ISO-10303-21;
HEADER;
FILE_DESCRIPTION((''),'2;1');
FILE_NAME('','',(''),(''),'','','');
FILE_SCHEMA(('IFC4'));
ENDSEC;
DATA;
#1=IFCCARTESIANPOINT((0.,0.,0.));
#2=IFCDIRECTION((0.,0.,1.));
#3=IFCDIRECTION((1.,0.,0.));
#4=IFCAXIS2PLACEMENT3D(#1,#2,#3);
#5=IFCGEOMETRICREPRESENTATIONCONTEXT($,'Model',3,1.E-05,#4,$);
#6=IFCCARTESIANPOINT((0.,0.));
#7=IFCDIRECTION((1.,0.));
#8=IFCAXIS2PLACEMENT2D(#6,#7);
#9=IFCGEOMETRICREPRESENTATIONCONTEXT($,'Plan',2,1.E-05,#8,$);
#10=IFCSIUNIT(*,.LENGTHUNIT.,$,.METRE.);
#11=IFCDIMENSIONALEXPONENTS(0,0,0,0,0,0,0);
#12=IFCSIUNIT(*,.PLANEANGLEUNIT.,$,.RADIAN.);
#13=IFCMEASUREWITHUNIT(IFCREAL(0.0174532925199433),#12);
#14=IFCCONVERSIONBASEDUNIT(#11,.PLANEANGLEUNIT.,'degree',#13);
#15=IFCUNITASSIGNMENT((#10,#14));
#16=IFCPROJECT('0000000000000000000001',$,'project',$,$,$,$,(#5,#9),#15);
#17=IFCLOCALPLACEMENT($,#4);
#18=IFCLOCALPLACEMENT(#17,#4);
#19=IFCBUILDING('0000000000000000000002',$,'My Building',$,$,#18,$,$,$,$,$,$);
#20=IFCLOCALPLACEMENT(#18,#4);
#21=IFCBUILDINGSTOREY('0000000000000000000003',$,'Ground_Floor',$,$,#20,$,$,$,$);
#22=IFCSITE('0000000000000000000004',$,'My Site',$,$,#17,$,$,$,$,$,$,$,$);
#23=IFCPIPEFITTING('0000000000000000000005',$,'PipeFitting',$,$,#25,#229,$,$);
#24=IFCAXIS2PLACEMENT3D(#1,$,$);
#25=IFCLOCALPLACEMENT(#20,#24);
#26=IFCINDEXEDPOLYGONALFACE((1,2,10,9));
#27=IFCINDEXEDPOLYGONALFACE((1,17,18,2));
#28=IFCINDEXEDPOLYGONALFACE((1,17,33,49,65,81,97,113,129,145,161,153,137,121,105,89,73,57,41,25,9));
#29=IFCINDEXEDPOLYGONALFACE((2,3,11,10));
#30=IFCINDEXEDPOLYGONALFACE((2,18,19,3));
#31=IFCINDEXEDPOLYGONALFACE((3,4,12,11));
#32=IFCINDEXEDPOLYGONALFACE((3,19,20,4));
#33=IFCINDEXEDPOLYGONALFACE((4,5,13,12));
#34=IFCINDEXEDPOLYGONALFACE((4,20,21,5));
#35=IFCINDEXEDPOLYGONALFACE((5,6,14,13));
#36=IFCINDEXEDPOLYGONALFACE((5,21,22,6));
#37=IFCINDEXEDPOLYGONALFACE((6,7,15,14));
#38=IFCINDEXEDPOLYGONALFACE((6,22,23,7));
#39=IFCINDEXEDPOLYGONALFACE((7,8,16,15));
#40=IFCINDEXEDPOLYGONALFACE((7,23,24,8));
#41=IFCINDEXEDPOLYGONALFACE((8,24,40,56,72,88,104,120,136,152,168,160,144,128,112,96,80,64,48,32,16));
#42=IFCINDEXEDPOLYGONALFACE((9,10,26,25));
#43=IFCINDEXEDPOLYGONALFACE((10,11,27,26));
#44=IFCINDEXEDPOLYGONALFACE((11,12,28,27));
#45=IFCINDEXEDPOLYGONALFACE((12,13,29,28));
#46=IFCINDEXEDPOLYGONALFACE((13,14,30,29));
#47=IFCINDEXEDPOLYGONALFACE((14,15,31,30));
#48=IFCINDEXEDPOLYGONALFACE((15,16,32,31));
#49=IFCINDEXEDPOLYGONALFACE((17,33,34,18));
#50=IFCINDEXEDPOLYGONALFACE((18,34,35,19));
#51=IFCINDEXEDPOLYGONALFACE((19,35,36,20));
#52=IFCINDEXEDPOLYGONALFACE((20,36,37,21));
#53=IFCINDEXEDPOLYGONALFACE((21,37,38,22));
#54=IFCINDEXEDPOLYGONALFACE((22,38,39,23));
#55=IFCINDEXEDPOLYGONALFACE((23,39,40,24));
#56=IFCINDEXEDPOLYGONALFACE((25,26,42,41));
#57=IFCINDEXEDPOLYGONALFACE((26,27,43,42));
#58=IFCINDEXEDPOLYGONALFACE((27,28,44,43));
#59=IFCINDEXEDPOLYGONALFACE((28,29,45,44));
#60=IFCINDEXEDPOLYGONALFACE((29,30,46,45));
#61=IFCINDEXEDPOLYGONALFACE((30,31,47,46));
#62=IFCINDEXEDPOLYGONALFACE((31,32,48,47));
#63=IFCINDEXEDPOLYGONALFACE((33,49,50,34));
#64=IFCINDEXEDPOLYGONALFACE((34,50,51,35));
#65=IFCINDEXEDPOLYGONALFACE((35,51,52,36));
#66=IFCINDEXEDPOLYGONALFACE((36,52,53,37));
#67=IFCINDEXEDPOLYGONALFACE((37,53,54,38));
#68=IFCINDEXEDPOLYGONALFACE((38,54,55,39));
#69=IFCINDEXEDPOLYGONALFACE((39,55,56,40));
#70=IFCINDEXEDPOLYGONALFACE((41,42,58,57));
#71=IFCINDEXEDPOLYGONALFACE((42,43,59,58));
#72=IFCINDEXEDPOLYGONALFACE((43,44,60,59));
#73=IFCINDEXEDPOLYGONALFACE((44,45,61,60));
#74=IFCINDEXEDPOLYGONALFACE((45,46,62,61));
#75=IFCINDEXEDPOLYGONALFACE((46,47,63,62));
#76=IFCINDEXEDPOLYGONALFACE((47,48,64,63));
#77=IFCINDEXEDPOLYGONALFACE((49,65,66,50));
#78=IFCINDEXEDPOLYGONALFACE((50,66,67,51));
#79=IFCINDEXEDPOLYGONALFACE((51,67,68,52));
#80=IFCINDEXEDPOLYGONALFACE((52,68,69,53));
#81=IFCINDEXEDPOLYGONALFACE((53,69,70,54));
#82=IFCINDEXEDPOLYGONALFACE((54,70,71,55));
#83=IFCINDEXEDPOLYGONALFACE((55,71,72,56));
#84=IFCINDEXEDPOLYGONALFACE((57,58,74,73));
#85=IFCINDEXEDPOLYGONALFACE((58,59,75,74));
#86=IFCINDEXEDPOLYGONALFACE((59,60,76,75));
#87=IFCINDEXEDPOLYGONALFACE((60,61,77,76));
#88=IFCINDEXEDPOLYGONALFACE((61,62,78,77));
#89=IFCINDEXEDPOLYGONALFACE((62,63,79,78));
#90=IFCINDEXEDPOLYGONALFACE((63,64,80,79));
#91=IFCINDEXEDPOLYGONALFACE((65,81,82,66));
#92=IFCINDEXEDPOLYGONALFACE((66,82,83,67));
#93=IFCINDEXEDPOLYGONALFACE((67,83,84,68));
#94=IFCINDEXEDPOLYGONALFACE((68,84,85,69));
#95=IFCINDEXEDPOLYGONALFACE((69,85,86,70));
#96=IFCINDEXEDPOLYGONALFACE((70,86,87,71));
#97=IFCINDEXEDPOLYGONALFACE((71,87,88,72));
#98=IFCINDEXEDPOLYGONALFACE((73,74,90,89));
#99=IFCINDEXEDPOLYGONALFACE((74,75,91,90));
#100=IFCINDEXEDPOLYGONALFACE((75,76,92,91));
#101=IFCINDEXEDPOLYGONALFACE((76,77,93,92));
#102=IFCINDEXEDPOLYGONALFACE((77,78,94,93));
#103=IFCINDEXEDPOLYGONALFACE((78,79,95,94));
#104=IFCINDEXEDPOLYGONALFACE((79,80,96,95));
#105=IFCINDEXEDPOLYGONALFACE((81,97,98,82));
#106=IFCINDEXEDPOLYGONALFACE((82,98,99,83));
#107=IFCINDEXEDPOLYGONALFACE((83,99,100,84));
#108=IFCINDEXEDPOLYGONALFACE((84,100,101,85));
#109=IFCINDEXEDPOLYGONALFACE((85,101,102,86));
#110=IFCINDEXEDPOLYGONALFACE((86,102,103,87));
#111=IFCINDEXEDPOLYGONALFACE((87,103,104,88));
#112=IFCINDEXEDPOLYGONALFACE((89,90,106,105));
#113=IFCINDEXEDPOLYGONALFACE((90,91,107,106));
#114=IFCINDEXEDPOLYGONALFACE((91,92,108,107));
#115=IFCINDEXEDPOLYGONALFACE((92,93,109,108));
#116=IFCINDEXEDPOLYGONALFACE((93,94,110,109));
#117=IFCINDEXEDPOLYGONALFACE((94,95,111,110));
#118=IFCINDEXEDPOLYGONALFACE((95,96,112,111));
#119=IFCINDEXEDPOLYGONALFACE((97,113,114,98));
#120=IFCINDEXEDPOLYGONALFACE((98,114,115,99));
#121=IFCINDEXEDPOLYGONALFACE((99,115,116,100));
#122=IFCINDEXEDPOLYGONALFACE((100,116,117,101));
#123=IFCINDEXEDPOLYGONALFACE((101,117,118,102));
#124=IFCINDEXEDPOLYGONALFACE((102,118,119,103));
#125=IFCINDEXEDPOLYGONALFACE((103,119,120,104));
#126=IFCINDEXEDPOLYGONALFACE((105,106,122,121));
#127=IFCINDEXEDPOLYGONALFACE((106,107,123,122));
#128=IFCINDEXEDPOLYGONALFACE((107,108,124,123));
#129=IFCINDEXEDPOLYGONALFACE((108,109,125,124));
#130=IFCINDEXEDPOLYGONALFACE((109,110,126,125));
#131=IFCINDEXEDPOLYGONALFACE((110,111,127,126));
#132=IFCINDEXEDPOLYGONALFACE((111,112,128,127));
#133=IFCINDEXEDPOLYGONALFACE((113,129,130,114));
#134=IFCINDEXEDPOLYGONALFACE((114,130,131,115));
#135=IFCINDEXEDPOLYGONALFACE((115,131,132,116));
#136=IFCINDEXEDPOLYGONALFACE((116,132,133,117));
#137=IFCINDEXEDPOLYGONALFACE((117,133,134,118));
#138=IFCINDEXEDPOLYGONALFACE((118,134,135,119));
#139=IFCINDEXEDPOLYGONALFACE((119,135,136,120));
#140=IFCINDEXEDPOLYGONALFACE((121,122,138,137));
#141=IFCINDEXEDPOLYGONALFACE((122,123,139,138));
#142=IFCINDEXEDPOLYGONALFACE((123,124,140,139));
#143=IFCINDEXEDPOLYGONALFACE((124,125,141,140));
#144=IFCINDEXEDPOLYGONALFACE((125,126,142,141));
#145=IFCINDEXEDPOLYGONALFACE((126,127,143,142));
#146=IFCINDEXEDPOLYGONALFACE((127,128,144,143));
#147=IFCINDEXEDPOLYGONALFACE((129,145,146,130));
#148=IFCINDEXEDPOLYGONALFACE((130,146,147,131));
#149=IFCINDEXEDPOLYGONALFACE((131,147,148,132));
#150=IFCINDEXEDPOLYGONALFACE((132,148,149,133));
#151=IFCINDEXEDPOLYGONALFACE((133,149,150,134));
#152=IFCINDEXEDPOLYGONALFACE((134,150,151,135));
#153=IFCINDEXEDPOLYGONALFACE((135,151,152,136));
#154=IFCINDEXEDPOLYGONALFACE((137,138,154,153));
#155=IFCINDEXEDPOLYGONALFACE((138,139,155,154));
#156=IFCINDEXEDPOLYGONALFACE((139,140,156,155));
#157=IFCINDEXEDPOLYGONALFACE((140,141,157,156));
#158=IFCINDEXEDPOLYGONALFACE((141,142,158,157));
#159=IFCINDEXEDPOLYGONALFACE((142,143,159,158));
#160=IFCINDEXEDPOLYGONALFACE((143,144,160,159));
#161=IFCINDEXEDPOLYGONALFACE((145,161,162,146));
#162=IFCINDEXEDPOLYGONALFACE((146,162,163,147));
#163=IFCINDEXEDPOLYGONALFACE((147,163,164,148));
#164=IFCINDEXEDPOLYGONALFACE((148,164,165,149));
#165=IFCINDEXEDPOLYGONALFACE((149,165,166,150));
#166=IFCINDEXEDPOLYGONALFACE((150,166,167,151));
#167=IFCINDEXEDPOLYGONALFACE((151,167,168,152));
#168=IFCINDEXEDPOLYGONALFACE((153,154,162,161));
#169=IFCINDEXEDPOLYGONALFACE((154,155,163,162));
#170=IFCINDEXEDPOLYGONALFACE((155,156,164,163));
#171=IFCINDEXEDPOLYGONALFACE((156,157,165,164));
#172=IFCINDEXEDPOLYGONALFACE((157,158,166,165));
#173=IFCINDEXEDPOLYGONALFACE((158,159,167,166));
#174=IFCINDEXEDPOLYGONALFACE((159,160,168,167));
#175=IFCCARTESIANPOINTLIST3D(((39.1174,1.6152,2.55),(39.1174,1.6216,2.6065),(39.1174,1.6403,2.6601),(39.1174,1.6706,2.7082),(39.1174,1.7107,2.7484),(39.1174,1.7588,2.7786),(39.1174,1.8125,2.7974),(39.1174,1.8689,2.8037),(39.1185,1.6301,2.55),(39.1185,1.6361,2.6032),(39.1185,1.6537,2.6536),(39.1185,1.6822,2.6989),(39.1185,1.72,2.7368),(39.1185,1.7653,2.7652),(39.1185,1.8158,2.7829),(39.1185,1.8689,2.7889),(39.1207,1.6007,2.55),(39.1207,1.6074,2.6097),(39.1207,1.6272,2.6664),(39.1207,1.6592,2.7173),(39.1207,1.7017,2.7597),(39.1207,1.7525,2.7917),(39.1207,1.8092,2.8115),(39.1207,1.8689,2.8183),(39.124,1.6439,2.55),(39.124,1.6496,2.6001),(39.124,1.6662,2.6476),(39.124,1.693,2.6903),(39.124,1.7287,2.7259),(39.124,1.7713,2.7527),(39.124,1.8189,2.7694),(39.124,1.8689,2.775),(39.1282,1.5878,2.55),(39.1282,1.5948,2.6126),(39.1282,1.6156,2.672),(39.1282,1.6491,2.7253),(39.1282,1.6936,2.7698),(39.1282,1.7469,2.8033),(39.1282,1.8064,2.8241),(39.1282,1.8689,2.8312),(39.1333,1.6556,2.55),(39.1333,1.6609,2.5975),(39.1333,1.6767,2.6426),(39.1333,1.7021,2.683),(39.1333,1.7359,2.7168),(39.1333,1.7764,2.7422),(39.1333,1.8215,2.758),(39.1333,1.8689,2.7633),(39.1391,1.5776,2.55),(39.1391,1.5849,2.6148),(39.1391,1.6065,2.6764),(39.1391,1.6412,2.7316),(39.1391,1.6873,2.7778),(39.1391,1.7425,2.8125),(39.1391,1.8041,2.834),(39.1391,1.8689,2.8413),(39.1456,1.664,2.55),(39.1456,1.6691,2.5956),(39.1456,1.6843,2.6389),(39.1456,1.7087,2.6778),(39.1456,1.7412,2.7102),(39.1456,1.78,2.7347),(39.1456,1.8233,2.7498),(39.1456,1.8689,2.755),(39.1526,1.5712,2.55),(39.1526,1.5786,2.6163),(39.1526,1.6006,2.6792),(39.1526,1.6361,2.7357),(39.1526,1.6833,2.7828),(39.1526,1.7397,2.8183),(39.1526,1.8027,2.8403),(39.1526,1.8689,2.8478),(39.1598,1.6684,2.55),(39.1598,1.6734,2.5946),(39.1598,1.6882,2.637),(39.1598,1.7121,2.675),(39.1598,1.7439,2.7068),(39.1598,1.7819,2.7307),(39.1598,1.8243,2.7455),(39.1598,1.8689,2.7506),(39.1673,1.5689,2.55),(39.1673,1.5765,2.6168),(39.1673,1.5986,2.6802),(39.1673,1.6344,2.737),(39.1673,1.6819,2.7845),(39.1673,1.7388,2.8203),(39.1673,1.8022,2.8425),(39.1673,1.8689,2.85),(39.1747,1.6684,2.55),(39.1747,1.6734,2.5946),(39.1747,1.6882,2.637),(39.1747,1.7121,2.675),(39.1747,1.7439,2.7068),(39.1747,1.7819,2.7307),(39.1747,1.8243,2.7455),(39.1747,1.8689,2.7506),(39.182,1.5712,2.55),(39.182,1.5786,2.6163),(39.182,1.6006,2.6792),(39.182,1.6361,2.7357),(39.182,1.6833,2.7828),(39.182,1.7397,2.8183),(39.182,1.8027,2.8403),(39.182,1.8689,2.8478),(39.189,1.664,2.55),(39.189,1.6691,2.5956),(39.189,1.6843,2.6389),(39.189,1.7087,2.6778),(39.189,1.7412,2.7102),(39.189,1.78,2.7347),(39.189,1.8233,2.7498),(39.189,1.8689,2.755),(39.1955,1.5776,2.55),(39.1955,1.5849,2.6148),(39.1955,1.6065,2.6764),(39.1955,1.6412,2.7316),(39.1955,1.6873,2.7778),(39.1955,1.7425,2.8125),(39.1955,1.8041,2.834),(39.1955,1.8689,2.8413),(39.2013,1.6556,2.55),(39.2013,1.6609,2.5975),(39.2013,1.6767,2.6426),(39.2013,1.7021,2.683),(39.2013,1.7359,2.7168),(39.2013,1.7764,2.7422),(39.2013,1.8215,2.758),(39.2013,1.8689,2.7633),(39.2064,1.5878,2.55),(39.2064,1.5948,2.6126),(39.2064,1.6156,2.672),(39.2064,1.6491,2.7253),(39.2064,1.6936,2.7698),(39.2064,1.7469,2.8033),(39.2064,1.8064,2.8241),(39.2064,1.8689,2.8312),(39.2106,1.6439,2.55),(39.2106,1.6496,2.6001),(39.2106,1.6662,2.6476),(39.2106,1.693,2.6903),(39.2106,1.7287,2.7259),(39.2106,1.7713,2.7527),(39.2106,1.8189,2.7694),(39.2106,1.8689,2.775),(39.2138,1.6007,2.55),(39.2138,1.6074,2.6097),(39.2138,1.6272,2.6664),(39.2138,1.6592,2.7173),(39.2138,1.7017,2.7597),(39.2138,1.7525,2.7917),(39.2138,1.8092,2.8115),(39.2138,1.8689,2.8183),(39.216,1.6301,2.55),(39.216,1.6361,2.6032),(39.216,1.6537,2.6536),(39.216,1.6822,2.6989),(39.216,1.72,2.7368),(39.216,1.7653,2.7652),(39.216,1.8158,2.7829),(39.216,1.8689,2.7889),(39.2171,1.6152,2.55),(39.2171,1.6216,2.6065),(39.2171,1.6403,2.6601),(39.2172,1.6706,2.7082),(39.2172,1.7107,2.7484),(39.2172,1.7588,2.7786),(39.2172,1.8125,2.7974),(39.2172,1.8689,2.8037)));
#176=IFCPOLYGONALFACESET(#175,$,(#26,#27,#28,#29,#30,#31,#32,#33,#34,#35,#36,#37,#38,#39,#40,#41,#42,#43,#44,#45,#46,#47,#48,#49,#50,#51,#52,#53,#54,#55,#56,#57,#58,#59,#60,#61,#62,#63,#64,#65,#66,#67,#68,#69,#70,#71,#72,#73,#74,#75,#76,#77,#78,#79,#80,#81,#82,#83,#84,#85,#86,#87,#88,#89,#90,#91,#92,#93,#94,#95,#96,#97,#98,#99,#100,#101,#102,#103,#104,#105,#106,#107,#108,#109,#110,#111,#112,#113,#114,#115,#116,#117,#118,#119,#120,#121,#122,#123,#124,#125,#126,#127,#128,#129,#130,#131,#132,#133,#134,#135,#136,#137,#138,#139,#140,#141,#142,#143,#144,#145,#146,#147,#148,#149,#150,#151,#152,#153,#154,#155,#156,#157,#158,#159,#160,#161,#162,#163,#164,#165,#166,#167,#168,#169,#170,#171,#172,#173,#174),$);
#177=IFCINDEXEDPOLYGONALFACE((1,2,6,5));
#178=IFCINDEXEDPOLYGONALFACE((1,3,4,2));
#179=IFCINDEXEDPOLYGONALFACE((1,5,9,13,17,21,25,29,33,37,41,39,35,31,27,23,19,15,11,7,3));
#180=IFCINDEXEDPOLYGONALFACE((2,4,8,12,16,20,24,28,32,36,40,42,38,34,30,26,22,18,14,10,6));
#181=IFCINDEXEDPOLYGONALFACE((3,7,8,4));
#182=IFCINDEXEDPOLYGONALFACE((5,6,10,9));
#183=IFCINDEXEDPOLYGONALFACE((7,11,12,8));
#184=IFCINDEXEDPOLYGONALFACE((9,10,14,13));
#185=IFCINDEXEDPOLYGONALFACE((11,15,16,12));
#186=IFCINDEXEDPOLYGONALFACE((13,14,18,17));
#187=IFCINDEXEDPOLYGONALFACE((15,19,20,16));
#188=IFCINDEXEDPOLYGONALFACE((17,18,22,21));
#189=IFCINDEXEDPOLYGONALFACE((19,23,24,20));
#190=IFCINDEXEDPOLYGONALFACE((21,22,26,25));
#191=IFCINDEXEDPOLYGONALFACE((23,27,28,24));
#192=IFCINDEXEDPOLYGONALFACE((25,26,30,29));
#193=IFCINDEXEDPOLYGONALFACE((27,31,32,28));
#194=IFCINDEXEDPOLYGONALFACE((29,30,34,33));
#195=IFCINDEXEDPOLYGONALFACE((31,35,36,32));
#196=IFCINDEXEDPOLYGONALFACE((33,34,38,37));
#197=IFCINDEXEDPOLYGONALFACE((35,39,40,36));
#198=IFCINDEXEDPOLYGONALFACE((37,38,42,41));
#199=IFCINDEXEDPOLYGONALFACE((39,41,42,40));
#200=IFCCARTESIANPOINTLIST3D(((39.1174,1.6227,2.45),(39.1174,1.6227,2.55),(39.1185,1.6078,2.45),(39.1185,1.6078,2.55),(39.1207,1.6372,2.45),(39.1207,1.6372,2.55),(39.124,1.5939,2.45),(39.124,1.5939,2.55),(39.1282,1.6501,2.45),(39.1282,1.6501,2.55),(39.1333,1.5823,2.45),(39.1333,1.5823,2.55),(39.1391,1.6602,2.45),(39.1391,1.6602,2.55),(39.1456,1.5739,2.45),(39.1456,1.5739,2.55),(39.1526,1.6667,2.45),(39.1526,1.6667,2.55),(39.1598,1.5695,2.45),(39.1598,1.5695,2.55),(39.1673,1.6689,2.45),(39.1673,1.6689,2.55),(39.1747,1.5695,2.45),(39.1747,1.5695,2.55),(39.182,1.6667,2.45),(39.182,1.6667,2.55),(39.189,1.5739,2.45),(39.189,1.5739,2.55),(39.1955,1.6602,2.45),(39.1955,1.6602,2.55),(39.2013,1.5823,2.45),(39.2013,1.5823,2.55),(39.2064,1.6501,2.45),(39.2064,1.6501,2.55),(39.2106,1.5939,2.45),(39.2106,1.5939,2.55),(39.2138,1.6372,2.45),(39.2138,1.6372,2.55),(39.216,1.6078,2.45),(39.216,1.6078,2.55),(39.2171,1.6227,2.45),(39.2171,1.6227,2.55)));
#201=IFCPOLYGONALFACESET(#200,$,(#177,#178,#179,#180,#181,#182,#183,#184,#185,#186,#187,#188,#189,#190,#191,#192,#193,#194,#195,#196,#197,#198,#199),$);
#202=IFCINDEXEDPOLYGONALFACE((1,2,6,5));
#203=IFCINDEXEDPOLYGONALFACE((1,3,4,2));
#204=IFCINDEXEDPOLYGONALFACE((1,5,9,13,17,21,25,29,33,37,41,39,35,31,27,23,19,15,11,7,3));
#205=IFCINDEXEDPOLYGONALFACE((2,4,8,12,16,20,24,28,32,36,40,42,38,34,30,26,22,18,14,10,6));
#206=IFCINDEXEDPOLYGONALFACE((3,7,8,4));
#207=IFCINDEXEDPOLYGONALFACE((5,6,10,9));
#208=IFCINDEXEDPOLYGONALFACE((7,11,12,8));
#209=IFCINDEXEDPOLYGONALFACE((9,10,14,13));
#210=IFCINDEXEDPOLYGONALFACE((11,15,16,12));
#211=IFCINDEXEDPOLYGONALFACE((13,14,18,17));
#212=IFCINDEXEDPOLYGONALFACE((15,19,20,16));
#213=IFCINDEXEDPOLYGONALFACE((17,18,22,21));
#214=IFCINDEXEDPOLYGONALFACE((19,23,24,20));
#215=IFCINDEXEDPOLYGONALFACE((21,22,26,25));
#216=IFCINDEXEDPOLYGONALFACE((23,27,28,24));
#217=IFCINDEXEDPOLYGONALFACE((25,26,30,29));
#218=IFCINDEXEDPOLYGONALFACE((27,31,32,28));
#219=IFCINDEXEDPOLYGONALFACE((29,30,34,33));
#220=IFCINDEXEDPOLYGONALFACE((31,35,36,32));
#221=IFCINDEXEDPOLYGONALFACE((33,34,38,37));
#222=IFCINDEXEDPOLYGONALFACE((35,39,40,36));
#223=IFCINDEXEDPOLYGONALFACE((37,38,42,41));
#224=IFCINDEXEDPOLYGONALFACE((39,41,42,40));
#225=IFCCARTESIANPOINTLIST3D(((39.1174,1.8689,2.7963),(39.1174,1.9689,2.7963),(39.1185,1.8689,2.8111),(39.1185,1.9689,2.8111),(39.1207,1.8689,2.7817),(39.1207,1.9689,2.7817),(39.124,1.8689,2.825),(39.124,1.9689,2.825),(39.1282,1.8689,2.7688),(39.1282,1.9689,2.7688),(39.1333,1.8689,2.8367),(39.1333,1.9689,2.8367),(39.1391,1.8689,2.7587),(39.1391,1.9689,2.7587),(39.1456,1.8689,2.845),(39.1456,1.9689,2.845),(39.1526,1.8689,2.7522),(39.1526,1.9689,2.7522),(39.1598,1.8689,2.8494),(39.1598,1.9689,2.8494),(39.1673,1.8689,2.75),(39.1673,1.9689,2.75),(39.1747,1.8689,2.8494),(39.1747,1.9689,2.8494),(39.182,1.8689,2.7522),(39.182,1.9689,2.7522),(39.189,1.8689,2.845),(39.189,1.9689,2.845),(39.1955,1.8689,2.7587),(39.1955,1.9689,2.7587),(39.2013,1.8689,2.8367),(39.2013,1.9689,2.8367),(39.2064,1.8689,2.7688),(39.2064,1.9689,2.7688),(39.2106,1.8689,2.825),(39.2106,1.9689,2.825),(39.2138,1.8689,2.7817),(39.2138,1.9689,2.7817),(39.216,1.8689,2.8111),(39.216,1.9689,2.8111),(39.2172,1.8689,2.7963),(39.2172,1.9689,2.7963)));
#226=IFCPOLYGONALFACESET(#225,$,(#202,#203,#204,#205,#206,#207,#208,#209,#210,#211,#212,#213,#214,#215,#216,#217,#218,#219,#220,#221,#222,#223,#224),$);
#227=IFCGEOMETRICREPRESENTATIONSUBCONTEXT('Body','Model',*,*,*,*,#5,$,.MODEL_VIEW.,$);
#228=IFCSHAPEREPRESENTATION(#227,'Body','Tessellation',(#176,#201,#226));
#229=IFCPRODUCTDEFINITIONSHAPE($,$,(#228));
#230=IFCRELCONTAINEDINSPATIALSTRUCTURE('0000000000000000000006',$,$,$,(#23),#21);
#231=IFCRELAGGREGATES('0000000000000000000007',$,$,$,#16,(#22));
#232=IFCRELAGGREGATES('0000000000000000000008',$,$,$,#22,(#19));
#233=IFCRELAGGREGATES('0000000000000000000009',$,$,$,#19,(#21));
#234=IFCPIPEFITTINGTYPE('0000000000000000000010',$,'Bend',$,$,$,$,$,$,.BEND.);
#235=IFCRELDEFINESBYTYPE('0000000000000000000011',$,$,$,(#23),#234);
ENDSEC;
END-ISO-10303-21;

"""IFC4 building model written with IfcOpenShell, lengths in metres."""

from ifc_helpers import new_model, entity, si_unit, converted_unit, frame, origin_with_axes, origin_2d_with_axis, place, context, subcontext, project, spatial, circle, extrude, source, transform, mapped, type_object, type_shapes, element, save


model = new_model("IFC4")

# Units and contexts
model_context = context("Model", 3, precision=1e-05, world=origin_with_axes())
plan_context = context("Plan", 2, precision=1e-05, world=origin_2d_with_axis())
body_context = subcontext(model_context, "Body", "Model", "MODEL_VIEW")
ifc_project = project(units=[si_unit("LENGTHUNIT", "METRE"), converted_unit("PLANEANGLEUNIT", "degree", entity("IfcReal", 0.0174532925199433), si_unit("PLANEANGLEUNIT", "RADIAN"), dimensions=[0, 0, 0, 0, 0, 0, 0])], contexts=[model_context, plan_context])

# Site, building, storey
site_placement = place(None, origin_with_axes())
site = spatial("IfcSite", under=ifc_project, at=site_placement, Name="My Site")
building_placement = place(site_placement, origin_with_axes())
building = spatial("IfcBuilding", under=site, at=building_placement, Name="My Building")
storey_placement = place(building_placement, origin_with_axes())
storey = spatial("IfcBuildingStorey", under=building, at=storey_placement, Name="Ground_Floor")

# Pipe fitting
pipe_fitting_type = type_object("IfcPipeFittingType", Name="Bend", PredefinedType="BEND")
shared_shape = source(origin_with_axes(), body_context, "Body", "SolidModel", [
    entity("IfcSweptDiskSolid", entity("IfcIndexedPolyCurve", entity("IfcCartesianPointList3D", [[0.0, 0.0, -0.1], [0.0732, 0.0, -0.2768], [0.25, 0.0, -0.35]]), [entity("IfcArcIndex", [1, 2, 3])]), 0.05),
    extrude(circle(Radius=0.05), origin_with_axes(), (0.0, 0.0, -1.0), 0.1),
    extrude(circle(Radius=0.05), frame((0.25, 0.0, -0.35), z_axis=(1.0, 0.0, 0.0), x_axis=(0.0, 0.0, 1.0)), (0.0, 0.0, 1.0), 0.1),
])
type_shapes(pipe_fitting_type, [shared_shape])
for number, where, z_axis, x_axis, name in (
    (1, (39.1673, 1.6189, 2.45), (0.0, 0.0, -1.0), (0.0, 1.0, 0.0), "PipeFitting"),
):
    element("IfcPipeFitting", number, at=place(storey_placement, frame(where, z_axis=z_axis, x_axis=x_axis)), inside=storey, type_object=pipe_fitting_type, Name=name, context=body_context, shape_type="MappedRepresentation", body=[
        mapped(shared_shape, transform((0.0, 0.0, 0.0), x_axis=(1.0, 0.0, 0.0), y_axis=(0.0, 1.0, 0.0), z_axis=(0.0, 0.0, 1.0), scale=1.0)),
    ])

save(model, "model.ifc")
